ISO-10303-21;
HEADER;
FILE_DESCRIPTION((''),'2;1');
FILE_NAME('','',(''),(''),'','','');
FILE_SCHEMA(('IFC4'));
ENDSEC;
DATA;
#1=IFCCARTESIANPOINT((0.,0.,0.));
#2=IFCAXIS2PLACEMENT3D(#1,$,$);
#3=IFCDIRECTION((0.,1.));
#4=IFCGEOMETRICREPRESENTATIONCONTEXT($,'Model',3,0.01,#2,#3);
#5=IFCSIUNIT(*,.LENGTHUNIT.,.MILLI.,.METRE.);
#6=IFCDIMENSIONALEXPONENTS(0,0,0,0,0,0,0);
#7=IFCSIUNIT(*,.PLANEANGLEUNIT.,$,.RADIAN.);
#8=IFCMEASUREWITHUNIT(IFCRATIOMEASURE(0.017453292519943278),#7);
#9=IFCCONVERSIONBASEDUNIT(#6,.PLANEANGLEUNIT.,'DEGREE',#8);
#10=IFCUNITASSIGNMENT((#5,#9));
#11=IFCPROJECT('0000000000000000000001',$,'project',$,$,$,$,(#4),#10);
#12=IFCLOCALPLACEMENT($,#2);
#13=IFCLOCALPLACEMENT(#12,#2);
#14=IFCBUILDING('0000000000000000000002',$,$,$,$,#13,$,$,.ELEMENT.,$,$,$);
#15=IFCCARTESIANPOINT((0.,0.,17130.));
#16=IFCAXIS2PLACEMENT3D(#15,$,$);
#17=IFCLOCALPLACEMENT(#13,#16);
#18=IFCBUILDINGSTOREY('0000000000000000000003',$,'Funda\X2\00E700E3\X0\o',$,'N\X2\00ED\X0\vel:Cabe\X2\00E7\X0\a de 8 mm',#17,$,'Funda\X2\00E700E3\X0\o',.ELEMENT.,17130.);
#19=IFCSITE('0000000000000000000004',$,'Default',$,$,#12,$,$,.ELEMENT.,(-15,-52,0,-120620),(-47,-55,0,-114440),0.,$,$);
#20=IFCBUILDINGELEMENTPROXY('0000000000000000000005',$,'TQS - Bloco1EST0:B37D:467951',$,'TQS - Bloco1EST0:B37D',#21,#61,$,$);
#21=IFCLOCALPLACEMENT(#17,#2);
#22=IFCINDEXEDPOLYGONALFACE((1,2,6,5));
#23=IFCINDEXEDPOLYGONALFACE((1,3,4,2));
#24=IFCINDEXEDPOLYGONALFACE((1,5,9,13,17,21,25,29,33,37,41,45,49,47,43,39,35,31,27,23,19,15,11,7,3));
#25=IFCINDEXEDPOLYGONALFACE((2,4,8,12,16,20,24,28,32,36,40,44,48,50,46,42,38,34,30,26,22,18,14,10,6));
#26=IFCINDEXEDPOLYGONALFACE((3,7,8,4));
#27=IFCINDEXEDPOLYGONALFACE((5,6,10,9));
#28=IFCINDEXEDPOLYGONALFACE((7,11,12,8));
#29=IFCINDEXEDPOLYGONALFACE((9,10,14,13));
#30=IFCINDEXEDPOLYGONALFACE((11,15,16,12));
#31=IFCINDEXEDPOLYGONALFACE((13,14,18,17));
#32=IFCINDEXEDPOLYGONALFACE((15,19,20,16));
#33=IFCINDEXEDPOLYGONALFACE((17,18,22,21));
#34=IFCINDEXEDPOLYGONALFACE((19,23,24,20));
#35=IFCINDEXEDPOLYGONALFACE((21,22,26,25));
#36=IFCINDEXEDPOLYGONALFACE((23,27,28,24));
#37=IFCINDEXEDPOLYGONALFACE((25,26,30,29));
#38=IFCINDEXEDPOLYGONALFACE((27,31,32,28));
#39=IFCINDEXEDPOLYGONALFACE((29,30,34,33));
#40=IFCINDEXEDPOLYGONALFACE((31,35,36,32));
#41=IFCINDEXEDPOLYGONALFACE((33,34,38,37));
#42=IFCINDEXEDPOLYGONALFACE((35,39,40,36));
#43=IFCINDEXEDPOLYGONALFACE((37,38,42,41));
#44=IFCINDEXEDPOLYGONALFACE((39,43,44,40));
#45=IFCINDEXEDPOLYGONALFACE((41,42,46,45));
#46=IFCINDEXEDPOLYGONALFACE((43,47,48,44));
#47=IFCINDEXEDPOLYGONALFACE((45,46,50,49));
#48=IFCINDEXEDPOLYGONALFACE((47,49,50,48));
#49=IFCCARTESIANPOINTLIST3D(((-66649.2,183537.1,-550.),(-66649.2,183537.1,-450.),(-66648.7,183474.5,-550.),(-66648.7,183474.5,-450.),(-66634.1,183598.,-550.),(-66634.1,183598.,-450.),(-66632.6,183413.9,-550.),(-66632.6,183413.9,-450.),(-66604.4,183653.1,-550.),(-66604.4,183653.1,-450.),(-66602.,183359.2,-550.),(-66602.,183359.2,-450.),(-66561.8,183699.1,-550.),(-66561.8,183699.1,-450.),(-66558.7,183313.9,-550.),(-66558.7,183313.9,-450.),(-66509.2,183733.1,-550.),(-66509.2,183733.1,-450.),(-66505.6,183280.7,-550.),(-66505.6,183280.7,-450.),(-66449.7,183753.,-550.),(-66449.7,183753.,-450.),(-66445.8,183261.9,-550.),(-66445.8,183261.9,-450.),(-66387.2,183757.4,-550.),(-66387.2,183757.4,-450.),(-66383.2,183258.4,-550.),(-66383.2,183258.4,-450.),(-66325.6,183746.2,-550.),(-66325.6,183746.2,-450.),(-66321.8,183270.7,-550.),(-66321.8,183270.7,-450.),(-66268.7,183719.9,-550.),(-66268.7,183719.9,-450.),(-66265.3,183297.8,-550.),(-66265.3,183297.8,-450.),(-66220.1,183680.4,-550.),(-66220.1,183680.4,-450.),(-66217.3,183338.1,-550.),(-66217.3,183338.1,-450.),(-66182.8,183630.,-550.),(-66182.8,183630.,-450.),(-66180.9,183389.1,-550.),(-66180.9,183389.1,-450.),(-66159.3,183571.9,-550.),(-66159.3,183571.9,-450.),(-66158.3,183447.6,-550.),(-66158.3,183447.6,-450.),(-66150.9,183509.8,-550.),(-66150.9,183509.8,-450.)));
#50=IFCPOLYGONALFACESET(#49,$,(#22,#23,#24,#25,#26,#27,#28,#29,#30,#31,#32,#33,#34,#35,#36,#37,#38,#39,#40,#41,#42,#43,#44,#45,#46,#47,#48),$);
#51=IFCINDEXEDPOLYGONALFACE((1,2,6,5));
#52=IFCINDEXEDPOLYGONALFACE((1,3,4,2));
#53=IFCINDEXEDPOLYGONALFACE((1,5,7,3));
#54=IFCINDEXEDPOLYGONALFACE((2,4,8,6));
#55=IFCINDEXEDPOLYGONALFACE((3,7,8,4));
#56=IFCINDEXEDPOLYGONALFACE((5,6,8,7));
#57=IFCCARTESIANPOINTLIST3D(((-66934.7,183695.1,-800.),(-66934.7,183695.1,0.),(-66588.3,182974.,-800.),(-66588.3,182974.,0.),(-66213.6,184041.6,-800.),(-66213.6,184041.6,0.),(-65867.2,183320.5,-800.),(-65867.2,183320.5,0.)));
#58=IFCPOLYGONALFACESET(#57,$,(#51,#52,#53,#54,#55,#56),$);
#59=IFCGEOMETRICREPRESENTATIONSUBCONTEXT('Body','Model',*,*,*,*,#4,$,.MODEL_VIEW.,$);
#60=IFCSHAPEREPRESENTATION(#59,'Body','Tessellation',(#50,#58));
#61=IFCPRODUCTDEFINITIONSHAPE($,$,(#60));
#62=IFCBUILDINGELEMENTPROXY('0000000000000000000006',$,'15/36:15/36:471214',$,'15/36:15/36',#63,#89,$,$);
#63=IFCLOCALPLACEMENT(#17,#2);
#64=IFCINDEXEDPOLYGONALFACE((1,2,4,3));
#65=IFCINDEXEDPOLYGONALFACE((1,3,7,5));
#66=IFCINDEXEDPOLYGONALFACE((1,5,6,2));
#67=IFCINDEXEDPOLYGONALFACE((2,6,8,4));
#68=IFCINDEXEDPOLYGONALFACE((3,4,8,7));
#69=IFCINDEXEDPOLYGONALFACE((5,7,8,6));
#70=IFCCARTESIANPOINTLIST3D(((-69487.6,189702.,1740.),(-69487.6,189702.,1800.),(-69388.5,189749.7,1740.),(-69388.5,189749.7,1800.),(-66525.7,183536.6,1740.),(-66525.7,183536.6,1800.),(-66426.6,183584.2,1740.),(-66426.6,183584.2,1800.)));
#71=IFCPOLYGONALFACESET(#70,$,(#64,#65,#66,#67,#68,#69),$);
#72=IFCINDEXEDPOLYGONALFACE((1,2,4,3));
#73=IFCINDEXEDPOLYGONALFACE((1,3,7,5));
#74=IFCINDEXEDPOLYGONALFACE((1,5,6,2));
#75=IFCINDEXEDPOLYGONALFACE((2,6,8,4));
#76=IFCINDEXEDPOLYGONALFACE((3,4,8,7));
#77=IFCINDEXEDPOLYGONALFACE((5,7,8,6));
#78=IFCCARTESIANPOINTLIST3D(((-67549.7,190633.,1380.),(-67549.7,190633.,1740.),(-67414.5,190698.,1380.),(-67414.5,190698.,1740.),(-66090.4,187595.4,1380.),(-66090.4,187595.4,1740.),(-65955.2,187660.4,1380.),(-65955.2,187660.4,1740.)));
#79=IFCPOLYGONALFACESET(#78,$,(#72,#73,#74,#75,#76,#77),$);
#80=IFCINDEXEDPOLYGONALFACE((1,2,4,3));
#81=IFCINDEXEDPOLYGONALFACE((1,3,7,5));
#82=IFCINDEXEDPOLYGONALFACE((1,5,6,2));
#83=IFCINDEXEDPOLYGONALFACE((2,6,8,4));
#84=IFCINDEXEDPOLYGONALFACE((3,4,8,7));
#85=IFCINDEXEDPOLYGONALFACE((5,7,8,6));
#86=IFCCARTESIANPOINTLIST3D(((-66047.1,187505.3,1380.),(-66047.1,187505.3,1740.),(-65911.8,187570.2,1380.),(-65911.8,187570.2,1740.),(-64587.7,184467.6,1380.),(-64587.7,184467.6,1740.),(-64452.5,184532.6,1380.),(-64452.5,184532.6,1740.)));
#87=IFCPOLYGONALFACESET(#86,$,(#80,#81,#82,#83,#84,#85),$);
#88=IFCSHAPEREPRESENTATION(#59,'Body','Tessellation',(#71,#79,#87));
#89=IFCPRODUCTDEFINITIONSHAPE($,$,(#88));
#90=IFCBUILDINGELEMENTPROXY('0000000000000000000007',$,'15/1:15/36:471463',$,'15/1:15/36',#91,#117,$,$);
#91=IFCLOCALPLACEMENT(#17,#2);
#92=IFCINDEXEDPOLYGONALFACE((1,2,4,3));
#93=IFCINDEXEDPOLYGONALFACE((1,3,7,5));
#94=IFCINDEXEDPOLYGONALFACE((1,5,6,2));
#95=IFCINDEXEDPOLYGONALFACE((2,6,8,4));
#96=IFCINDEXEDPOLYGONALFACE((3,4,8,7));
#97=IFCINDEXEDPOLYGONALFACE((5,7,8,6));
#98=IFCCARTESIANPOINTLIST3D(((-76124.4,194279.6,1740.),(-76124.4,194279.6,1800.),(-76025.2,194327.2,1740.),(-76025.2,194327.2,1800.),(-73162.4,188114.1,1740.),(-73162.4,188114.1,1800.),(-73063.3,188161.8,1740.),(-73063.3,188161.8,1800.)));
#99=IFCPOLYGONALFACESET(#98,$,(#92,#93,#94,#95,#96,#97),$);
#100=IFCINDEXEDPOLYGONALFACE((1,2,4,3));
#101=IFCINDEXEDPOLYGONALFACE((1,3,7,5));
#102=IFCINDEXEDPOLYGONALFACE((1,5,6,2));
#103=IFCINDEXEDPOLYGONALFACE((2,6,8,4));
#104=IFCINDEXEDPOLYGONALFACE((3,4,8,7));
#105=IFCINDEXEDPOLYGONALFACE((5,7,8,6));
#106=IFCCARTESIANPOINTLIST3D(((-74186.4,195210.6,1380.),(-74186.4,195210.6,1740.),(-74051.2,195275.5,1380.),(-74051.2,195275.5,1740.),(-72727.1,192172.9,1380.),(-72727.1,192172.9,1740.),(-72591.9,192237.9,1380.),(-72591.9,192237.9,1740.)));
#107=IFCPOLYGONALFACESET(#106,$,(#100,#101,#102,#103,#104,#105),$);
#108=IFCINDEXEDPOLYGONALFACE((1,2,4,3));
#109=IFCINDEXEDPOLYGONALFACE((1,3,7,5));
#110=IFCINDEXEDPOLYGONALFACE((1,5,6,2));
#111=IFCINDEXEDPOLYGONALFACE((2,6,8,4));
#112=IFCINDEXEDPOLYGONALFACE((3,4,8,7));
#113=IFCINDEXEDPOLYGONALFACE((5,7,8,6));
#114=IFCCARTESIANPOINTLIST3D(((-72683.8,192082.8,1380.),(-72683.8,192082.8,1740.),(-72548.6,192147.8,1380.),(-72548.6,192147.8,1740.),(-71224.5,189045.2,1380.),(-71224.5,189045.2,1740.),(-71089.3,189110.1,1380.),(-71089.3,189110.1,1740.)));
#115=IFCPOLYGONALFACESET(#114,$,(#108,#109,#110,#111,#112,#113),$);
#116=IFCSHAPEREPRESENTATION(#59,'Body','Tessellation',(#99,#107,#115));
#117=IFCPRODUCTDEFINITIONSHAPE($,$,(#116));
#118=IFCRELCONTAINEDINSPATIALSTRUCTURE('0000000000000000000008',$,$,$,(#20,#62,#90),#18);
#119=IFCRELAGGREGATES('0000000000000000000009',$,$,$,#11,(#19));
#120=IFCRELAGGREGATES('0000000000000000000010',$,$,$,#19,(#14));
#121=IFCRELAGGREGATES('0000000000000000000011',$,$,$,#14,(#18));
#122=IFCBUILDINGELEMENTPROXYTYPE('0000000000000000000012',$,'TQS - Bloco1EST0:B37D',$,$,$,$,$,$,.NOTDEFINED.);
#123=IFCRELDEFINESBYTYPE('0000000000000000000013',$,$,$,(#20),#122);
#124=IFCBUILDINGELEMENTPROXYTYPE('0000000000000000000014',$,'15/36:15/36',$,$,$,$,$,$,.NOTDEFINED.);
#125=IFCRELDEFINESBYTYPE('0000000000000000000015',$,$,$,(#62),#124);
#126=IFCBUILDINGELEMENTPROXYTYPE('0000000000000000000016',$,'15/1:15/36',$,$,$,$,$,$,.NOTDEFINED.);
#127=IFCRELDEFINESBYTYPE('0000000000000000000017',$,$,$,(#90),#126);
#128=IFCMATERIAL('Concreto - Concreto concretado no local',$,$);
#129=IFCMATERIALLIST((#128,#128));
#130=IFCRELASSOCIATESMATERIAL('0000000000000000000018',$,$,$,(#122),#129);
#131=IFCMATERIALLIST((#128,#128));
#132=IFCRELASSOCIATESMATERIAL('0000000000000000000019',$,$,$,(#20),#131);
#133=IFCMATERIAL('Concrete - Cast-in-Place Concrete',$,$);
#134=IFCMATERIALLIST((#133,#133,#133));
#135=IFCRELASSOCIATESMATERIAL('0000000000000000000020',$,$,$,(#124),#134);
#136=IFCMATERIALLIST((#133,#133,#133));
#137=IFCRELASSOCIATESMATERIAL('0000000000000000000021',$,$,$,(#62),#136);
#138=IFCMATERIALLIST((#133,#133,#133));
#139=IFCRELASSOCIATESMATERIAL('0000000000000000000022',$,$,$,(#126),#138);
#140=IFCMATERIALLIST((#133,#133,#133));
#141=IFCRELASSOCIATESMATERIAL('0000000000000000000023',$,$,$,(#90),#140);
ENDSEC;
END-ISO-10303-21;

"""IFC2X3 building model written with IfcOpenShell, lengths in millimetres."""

from ifc_helpers import new_model, entity, si_unit, converted_unit, direction, frame, frame_2d, origin, origin_2d_with_axis, place, context, subcontext, project, spatial, rectangle, circle, extrude, source, transform, mapped, material, material_list, type_object, type_shapes, element, save


model = new_model("IFC2X3")

# Units and contexts
model_context = context("Model", 3, precision=0.01, world=origin(), true_north=direction((0.0, 1.0)))
body_context = subcontext(model_context, "Body", "Model", "MODEL_VIEW")
ifc_project = project(units=[si_unit("LENGTHUNIT", "METRE", prefix="MILLI"), converted_unit("PLANEANGLEUNIT", "DEGREE", entity("IfcRatioMeasure", 0.017453292519943278), si_unit("PLANEANGLEUNIT", "RADIAN"), dimensions=[0, 0, 0, 0, 0, 0, 0])], contexts=[model_context])

# Site, building, storey
site_placement = place(None, origin())
site = spatial("IfcSite", under=ifc_project, at=site_placement, Name="Default", CompositionType="ELEMENT", RefLatitude=(-15, -52, 0, -120620), RefLongitude=(-47, -55, 0, -114440), RefElevation=0.0)
building_placement = place(site_placement, origin())
building = spatial("IfcBuilding", under=site, at=building_placement, CompositionType="ELEMENT")
storey_placement = place(building_placement, frame((0.0, 0.0, 17130.0)))
storey = spatial("IfcBuildingStorey", under=building, at=storey_placement, Name="Fundação", ObjectType="Nível:Cabeça de 8 mm", LongName="Fundação", CompositionType="ELEMENT", Elevation=17130.0)

# Building element proxies
ifc_material_1 = material(Name="Concreto - Concreto concretado no local")
ifc_material_list_1 = material_list([ifc_material_1, ifc_material_1])
ifc_material_list_2 = material_list([ifc_material_1, ifc_material_1])
building_element_proxy_type_1 = type_object("IfcBuildingElementProxyType", Name="TQS - Bloco1EST0:B37D", PredefinedType="NOTDEFINED", material=ifc_material_list_2)
shared_shape_1 = source(origin(), body_context, "Body", "SweptSolid", [
    extrude(circle(Radius=250.0, at=frame_2d((0.0, 0.0), x_axis=(1.0, 0.0))), frame((0.0, 0.0, -550.0)), (0.0, 0.0, 1.0), 100.0),
    extrude(rectangle(XDim=800.0, YDim=800.0, at=origin_2d_with_axis()), frame((0.0, 0.0, -800.0), z_axis=(0.0, 0.0, 1.0), x_axis=(-1.0, 0.0, 0.0)), (0.0, 0.0, 1.0), 800.0),
])
type_shapes(building_element_proxy_type_1, [shared_shape_1])
proxy_1_placement = place(storey_placement, frame((-66400.9, 183507.8, 0.0), z_axis=(0.0, 0.0, 1.0), x_axis=(-0.43303, 0.90138, 0.0)))
element("IfcBuildingElementProxy", 1, at=proxy_1_placement, inside=storey, type_object=building_element_proxy_type_1, material=ifc_material_list_1, Name="TQS - Bloco1EST0:B37D:467951", ObjectType="TQS - Bloco1EST0:B37D", context=body_context, shape_type="MappedRepresentation", body=[
    mapped(shared_shape_1, transform((0.0, 0.0, 0.0), scale=1.0)),
])
ifc_material_2 = material(Name="Concrete - Cast-in-Place Concrete")
ifc_material_list_3 = material_list([ifc_material_2, ifc_material_2, ifc_material_2])
ifc_material_list_4 = material_list([ifc_material_2, ifc_material_2, ifc_material_2])
building_element_proxy_type_2 = type_object("IfcBuildingElementProxyType", Name="15/36:15/36", PredefinedType="NOTDEFINED", material=ifc_material_list_4)
shared_shape_2 = source(origin(), body_context, "Body", "SweptSolid", [
    extrude(rectangle(XDim=110.0, YDim=6840.0, at=frame_2d((0.0, 0.0), x_axis=(1.0, 0.0))), frame((1530.5, 3106.5, 360.0), z_axis=(0.0, 0.0, 1.0), x_axis=(0.90138, 0.43303, 0.0)), (0.0, 0.0, 1.0), 60.0),
    extrude(rectangle(XDim=3370.0, YDim=150.0, at=frame_2d((0.0, 0.0), x_axis=(1.0, 0.0))), frame((2735.2, 5610.1, 0.0), z_axis=(0.0, 0.0, 1.0), x_axis=(0.43303, -0.90138, 0.0)), (0.0, 0.0, 1.0), 360.0),
    extrude(rectangle(XDim=3370.0, YDim=150.0, at=frame_2d((0.0, 0.0), x_axis=(1.0, 0.0))), frame((4237.8, 2482.3, 0.0), z_axis=(0.0, 0.0, 1.0), x_axis=(0.43303, -0.90138, 0.0)), (0.0, 0.0, 1.0), 360.0),
])
type_shapes(building_element_proxy_type_2, [shared_shape_2])
proxy_2_placement = place(storey_placement, frame((-69487.6, 183536.6, 1380.0)))
element("IfcBuildingElementProxy", 2, at=proxy_2_placement, inside=storey, type_object=building_element_proxy_type_2, material=ifc_material_list_3, Name="15/36:15/36:471214", ObjectType="15/36:15/36", context=body_context, shape_type="MappedRepresentation", body=[
    mapped(shared_shape_2, transform((0.0, 0.0, 0.0), scale=1.0)),
])
ifc_material_list_5 = material_list([ifc_material_2, ifc_material_2, ifc_material_2])
ifc_material_list_6 = material_list([ifc_material_2, ifc_material_2, ifc_material_2])
building_element_proxy_type_3 = type_object("IfcBuildingElementProxyType", Name="15/1:15/36", PredefinedType="NOTDEFINED", material=ifc_material_list_6)
shared_shape_3 = source(origin(), body_context, "Body", "SweptSolid", [
    extrude(rectangle(XDim=110.0, YDim=6840.0, at=frame_2d((0.0, 0.0), x_axis=(1.0, 0.0))), frame((1530.5, 3106.5, 360.0), z_axis=(0.0, 0.0, 1.0), x_axis=(0.90138, 0.43303, 0.0)), (0.0, 0.0, 1.0), 60.0),
    extrude(rectangle(XDim=3370.0, YDim=150.0, at=frame_2d((0.0, 0.0), x_axis=(1.0, 0.0))), frame((2735.2, 5610.1, 0.0), z_axis=(0.0, 0.0, 1.0), x_axis=(0.43303, -0.90138, 0.0)), (0.0, 0.0, 1.0), 360.0),
    extrude(rectangle(XDim=3370.0, YDim=150.0, at=frame_2d((0.0, 0.0), x_axis=(1.0, 0.0))), frame((4237.8, 2482.3, 0.0), z_axis=(0.0, 0.0, 1.0), x_axis=(0.43303, -0.90138, 0.0)), (0.0, 0.0, 1.0), 360.0),
])
type_shapes(building_element_proxy_type_3, [shared_shape_3])
proxy_3_placement = place(storey_placement, frame((-76124.4, 188114.1, 1380.0)))
element("IfcBuildingElementProxy", 3, at=proxy_3_placement, inside=storey, type_object=building_element_proxy_type_3, material=ifc_material_list_5, Name="15/1:15/36:471463", ObjectType="15/1:15/36", context=body_context, shape_type="MappedRepresentation", body=[
    mapped(shared_shape_3, transform((0.0, 0.0, 0.0), scale=1.0)),
])

save(model, "model.ifc")
